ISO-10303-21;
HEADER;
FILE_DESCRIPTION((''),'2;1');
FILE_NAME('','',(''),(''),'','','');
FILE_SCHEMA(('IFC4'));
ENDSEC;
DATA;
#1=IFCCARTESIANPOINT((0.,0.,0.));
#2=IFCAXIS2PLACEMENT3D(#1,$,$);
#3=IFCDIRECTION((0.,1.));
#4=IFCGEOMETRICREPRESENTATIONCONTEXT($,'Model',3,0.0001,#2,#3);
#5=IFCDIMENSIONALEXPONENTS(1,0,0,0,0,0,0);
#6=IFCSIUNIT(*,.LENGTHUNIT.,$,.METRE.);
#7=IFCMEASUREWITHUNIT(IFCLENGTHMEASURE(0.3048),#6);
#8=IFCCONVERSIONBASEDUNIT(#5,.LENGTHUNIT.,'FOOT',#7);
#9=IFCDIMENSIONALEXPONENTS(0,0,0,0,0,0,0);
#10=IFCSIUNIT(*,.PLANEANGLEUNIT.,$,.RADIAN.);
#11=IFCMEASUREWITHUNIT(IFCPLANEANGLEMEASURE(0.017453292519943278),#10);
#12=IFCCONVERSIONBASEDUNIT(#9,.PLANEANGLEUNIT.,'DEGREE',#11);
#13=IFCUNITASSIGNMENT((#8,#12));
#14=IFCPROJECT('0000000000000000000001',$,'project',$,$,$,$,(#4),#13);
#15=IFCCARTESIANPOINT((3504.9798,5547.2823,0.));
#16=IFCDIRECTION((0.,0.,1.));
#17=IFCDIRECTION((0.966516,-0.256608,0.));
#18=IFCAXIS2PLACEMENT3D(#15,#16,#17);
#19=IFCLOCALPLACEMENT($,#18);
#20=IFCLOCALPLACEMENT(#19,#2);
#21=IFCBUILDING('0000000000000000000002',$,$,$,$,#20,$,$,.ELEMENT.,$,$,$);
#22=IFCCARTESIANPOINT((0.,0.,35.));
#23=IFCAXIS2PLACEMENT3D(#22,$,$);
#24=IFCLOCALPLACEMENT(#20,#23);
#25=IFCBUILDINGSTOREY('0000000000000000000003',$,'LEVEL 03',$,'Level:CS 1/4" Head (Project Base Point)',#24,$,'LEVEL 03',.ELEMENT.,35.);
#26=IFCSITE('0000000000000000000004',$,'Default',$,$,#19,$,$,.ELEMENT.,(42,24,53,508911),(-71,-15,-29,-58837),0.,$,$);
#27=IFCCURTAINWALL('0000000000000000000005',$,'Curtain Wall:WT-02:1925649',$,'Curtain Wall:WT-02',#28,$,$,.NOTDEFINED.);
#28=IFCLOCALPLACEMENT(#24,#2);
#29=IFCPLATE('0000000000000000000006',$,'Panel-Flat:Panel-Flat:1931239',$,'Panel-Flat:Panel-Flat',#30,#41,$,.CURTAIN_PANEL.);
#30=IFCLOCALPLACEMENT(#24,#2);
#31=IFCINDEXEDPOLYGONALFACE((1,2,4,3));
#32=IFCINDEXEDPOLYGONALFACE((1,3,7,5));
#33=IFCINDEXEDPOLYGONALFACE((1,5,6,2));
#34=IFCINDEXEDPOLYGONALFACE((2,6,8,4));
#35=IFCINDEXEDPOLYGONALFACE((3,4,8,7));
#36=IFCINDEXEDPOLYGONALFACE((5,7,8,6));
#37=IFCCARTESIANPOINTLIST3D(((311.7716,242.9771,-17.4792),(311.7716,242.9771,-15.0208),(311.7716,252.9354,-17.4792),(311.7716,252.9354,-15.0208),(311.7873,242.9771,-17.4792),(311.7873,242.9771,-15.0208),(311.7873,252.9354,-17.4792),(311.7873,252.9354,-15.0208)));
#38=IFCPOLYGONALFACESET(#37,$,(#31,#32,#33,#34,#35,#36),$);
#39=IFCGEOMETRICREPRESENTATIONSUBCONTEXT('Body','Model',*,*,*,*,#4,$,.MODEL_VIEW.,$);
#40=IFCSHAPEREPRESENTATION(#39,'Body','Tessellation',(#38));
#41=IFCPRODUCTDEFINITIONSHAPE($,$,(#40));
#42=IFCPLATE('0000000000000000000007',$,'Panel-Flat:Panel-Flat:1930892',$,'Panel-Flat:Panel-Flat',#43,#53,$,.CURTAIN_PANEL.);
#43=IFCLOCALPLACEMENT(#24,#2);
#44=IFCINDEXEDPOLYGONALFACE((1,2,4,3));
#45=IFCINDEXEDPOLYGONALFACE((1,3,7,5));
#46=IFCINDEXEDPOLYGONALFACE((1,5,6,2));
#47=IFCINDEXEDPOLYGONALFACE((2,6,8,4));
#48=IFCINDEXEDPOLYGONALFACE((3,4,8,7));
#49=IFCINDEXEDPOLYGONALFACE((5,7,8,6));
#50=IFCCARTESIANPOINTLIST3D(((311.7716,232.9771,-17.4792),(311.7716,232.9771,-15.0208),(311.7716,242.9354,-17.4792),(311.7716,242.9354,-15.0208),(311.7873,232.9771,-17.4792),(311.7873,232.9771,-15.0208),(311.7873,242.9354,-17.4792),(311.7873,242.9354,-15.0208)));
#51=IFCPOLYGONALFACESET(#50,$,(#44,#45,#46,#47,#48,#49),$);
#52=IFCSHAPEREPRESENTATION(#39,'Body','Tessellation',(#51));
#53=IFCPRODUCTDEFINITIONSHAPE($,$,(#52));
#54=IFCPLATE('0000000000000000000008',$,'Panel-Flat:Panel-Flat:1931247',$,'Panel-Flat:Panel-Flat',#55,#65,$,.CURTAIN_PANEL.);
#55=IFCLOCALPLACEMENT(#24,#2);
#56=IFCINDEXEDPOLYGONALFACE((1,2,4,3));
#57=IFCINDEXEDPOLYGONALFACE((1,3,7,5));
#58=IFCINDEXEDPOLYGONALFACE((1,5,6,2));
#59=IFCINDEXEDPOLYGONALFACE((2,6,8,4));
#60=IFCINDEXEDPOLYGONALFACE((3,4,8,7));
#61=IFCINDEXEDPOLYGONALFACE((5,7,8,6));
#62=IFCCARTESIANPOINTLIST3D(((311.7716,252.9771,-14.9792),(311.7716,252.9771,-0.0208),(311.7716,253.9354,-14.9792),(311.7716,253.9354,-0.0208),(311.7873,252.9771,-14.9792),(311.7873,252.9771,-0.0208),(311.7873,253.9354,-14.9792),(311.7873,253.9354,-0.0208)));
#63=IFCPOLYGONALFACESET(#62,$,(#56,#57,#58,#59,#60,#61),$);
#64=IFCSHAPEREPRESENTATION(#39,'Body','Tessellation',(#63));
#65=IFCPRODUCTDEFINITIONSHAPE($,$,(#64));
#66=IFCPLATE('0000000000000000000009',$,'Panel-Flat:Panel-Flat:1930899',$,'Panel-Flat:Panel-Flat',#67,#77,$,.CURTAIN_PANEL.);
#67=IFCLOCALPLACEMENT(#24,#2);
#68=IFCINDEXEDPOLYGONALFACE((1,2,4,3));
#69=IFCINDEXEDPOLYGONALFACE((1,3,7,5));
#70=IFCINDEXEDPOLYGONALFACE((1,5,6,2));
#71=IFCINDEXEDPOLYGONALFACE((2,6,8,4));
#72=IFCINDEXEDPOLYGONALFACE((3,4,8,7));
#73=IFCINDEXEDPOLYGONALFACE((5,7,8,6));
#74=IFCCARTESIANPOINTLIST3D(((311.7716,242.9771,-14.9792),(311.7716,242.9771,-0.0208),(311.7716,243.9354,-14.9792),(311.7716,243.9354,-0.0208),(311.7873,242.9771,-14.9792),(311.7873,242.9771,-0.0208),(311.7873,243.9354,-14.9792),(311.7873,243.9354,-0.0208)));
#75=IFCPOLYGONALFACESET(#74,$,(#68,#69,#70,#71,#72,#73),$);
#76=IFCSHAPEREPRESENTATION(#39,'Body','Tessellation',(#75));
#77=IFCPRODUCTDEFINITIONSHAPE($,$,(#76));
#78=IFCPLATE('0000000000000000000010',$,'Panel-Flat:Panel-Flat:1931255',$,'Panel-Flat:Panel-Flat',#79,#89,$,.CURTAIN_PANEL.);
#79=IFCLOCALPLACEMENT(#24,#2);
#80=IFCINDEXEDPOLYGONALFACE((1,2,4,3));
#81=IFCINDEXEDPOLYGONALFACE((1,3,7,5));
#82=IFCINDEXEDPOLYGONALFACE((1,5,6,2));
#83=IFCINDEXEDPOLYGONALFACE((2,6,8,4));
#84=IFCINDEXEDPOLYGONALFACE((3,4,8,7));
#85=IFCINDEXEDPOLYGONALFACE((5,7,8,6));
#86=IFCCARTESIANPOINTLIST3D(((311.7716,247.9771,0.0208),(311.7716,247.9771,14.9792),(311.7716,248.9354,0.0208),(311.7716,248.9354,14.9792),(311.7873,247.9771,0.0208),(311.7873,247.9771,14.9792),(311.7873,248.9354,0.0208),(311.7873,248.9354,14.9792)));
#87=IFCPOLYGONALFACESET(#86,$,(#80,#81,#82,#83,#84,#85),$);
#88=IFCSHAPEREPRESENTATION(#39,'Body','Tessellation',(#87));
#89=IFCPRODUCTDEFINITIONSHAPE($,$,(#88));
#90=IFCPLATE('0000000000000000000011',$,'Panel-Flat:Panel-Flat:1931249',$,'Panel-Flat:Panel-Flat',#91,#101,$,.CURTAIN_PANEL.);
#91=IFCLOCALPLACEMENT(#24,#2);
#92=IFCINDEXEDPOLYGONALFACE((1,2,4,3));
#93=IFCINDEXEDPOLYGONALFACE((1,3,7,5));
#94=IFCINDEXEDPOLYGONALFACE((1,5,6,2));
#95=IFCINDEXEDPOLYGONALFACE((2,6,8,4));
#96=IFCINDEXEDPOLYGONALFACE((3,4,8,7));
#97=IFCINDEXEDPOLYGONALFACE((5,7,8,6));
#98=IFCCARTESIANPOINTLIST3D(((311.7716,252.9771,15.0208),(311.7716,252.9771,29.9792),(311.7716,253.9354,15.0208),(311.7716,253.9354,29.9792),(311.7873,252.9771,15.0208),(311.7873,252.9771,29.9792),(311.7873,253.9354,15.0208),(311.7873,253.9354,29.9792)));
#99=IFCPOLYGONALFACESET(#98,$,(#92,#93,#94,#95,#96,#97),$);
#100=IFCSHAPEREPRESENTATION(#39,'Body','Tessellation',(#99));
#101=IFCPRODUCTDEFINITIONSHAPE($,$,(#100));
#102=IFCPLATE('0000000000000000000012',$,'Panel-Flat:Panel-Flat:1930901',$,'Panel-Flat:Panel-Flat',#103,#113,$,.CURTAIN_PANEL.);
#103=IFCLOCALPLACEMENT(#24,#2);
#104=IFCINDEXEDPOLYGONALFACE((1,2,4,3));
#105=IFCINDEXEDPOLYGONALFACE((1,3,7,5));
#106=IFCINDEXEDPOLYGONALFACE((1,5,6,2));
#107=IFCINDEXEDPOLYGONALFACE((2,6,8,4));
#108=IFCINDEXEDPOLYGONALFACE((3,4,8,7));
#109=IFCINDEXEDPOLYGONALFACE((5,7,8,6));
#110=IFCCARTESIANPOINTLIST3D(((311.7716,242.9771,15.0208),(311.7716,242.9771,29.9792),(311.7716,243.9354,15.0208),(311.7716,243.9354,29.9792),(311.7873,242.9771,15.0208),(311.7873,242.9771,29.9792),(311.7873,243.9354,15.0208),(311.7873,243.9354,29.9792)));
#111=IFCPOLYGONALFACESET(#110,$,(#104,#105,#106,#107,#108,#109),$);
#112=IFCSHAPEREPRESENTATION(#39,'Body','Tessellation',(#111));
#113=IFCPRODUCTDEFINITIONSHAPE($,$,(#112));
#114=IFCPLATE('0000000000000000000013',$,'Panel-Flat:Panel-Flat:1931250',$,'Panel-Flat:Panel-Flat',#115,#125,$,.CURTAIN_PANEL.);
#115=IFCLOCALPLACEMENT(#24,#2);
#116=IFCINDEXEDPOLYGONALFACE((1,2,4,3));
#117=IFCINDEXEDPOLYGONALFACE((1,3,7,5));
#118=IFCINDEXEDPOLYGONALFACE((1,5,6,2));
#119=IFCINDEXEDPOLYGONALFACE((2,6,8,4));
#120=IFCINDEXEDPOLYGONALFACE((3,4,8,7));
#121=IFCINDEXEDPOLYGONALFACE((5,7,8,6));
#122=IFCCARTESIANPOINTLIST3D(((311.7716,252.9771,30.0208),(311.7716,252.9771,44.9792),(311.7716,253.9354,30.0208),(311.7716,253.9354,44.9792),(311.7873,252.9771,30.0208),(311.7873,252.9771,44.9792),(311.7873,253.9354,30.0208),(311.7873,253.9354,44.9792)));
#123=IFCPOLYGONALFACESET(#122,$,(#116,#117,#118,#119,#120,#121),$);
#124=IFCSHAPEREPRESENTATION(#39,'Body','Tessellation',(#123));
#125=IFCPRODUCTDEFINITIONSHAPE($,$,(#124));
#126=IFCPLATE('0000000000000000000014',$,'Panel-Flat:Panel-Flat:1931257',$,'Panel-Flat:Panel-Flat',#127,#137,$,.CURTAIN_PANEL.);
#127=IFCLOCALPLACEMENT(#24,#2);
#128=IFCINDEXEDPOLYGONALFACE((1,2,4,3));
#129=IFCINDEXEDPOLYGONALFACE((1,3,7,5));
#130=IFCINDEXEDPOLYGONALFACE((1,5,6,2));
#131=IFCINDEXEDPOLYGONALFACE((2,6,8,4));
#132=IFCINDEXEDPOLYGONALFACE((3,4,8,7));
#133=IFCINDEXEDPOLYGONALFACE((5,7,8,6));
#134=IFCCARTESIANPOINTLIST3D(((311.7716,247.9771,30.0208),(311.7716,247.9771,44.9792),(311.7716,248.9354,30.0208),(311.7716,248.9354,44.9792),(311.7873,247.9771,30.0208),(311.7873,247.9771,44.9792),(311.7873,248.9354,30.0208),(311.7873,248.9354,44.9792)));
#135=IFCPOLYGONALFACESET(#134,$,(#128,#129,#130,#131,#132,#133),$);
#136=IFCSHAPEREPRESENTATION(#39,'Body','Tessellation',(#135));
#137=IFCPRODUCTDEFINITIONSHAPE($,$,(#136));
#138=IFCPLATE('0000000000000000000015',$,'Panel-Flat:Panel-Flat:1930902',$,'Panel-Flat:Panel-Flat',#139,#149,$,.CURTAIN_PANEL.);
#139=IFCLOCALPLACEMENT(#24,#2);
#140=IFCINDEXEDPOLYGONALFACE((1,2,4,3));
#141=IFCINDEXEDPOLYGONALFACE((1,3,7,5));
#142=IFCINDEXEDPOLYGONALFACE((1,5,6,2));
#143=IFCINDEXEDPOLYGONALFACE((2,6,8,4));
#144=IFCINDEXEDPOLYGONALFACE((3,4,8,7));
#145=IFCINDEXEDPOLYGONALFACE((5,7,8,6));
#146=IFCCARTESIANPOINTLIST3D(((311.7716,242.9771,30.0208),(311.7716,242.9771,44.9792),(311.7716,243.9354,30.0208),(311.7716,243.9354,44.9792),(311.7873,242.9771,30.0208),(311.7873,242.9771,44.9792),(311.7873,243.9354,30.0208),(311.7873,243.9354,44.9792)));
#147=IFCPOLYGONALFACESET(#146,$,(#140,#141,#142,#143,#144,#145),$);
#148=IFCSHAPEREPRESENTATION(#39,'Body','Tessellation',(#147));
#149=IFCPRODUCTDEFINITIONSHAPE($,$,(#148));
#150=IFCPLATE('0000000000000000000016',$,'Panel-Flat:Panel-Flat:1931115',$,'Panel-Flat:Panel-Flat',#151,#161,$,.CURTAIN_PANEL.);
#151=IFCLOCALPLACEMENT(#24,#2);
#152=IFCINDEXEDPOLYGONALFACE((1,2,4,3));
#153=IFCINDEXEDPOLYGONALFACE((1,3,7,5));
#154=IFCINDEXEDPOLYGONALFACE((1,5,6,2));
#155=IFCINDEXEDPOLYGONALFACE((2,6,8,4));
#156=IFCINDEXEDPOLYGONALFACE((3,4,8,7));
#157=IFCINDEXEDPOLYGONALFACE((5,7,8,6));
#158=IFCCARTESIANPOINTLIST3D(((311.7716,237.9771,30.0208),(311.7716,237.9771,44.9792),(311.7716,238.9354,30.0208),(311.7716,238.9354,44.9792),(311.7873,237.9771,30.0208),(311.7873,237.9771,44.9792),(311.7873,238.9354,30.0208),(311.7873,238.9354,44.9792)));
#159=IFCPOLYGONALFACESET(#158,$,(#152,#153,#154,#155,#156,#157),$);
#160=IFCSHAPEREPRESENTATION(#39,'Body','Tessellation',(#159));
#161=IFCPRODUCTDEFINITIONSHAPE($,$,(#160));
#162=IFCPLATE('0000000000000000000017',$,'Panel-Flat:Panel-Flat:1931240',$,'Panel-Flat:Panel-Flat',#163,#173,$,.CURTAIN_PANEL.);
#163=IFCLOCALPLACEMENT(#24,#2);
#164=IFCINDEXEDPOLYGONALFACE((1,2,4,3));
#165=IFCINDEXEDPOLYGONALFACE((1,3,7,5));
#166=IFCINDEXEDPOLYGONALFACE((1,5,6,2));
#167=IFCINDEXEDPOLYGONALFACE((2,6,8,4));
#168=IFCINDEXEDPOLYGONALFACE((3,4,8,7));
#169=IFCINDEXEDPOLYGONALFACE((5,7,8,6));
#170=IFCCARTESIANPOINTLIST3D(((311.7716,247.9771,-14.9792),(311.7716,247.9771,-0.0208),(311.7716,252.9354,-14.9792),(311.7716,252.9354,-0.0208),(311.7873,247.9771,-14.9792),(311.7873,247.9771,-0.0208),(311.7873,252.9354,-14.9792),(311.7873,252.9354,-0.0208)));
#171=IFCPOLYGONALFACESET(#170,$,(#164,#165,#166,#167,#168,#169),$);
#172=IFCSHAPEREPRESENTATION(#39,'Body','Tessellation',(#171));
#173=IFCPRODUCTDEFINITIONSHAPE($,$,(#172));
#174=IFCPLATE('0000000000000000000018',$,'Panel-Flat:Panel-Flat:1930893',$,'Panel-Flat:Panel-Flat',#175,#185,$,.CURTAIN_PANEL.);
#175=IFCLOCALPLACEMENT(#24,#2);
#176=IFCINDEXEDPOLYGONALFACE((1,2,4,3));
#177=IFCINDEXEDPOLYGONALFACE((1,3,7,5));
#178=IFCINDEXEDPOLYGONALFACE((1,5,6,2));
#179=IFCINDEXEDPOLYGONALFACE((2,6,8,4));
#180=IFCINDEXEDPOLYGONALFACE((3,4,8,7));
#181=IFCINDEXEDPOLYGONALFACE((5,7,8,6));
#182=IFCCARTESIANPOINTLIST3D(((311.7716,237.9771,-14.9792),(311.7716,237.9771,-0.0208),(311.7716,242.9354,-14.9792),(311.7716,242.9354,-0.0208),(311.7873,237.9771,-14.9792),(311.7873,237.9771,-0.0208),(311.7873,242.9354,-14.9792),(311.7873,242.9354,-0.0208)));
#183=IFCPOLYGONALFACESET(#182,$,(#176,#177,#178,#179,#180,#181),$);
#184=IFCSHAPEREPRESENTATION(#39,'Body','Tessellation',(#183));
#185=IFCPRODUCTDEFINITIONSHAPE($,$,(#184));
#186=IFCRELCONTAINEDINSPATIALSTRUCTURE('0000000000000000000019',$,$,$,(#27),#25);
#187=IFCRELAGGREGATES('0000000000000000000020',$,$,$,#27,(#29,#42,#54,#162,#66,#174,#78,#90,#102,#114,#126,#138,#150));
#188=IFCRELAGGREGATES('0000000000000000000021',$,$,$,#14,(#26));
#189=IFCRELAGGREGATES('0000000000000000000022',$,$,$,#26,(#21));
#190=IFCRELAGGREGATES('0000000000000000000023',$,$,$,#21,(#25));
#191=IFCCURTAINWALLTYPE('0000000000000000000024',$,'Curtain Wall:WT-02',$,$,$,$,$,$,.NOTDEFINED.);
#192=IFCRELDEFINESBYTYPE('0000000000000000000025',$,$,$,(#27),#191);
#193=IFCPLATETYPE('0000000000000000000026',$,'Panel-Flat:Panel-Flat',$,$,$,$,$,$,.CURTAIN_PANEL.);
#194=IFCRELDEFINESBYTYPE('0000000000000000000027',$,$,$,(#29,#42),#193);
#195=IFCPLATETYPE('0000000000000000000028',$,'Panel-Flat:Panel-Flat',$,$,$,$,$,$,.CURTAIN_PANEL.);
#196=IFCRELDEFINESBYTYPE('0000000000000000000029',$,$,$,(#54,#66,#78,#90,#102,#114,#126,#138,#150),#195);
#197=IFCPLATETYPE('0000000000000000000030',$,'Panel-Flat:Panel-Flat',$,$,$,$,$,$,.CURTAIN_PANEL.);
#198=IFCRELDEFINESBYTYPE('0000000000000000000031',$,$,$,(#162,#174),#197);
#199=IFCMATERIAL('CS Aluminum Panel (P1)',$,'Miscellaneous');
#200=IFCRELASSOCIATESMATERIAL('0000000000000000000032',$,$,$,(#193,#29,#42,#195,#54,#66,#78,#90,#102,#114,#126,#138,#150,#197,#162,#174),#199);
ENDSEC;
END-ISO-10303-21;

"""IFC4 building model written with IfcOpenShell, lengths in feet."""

from ifc_helpers import new_model, entity, si_unit, converted_unit, direction, frame, origin, place, context, subcontext, project, spatial, indexed_curve, outline, extrude, source, transform, mapped, material, type_object, type_shapes, element, aggregate, save


model = new_model("IFC4")

# Units and contexts
model_context = context("Model", 3, precision=0.0001, world=origin(), true_north=direction((0.0, 1.0)))
body_context = subcontext(model_context, "Body", "Model", "MODEL_VIEW")
ifc_project = project(units=[converted_unit("LENGTHUNIT", "FOOT", entity("IfcLengthMeasure", 0.3048), si_unit("LENGTHUNIT", "METRE"), dimensions=[1, 0, 0, 0, 0, 0, 0]), converted_unit("PLANEANGLEUNIT", "DEGREE", entity("IfcPlaneAngleMeasure", 0.017453292519943278), si_unit("PLANEANGLEUNIT", "RADIAN"), dimensions=[0, 0, 0, 0, 0, 0, 0])], contexts=[model_context])

# Site, building, storey
site_placement = place(None, frame((3504.9798, 5547.2823, 0.0), z_axis=(0.0, 0.0, 1.0), x_axis=(0.966516, -0.256608, 0.0)))
site = spatial("IfcSite", under=ifc_project, at=site_placement, Name="Default", CompositionType="ELEMENT", RefLatitude=(42, 24, 53, 508911), RefLongitude=(-71, -15, -29, -58837), RefElevation=0.0)
building_placement = place(site_placement, origin())
building = spatial("IfcBuilding", under=site, at=building_placement, CompositionType="ELEMENT")
storey_placement = place(building_placement, frame((0.0, 0.0, 35.0)))
storey = spatial("IfcBuildingStorey", under=building, at=storey_placement, Name="LEVEL 03", ObjectType="Level:CS 1/4\" Head (Project Base Point)", LongName="LEVEL 03", CompositionType="ELEMENT", Elevation=35.0)

# Curtain wall, plates
curtain_wall_type = type_object("IfcCurtainWallType", Name="Curtain Wall:WT-02", PredefinedType="NOTDEFINED")
curtain_wall_1_placement = place(storey_placement, frame((0.0, 0.0, -35.0)))
curtain_wall_1 = element("IfcCurtainWall", 1, at=curtain_wall_1_placement, inside=storey, type_object=curtain_wall_type, Name="Curtain Wall:WT-02:1925649", ObjectType="Curtain Wall:WT-02", PredefinedType="NOTDEFINED")
ifc_material_1 = material(Name="CS Aluminum Panel (P1)", Category="Miscellaneous")
plate_type_1 = type_object("IfcPlateType", Name="Panel-Flat:Panel-Flat", PredefinedType="CURTAIN_PANEL", material=ifc_material_1)
shared_shape_1 = source(origin(), body_context, "Body", "SweptSolid", [
    extrude(outline(indexed_curve([(-0.0078, -4.9792), (0.0078, -4.9792), (0.0078, 4.9792), (-0.0078, 4.9792), (-0.0078, -4.9792)], self_intersect=False)), frame((4.9792, 0.0078, 0.0), z_axis=(0.0, 0.0, 1.0), x_axis=(0.0, -1.0, 0.0)), (0.0, 0.0, 1.0), 2.4583),
])
type_shapes(plate_type_1, [shared_shape_1])
plate_1_placement = place(curtain_wall_1_placement, frame((311.7716, 252.9354, 17.5208), z_axis=(0.0, 0.0, 1.0), x_axis=(0.0, -1.0, 0.0)))
plate_1 = element("IfcPlate", 2, at=plate_1_placement, type_object=plate_type_1, material=ifc_material_1, Name="Panel-Flat:Panel-Flat:1931239", ObjectType="Panel-Flat:Panel-Flat", PredefinedType="CURTAIN_PANEL", context=body_context, shape_type="MappedRepresentation", body=[
    mapped(shared_shape_1, transform((0.0, 0.0, 0.0), scale=1.0)),
])
plate_2_placement = place(curtain_wall_1_placement, frame((311.7716, 242.9354, 17.5208), z_axis=(0.0, 0.0, 1.0), x_axis=(0.0, -1.0, 0.0)))
plate_2 = element("IfcPlate", 3, at=plate_2_placement, type_object=plate_type_1, material=ifc_material_1, Name="Panel-Flat:Panel-Flat:1930892", ObjectType="Panel-Flat:Panel-Flat", PredefinedType="CURTAIN_PANEL", context=body_context, shape_type="MappedRepresentation", body=[
    mapped(shared_shape_1, transform((0.0, 0.0, 0.0), scale=1.0)),
])
plate_type_2 = type_object("IfcPlateType", Name="Panel-Flat:Panel-Flat", PredefinedType="CURTAIN_PANEL", material=ifc_material_1)
shared_shape_2 = source(origin(), body_context, "Body", "SweptSolid", [
    extrude(outline(indexed_curve([(-0.0078, -0.4792), (0.0078, -0.4792), (0.0078, 0.4792), (-0.0078, 0.4792), (-0.0078, -0.4792)], self_intersect=False)), frame((0.4792, 0.0078, 0.0), z_axis=(0.0, 0.0, 1.0), x_axis=(0.0, -1.0, 0.0)), (0.0, 0.0, 1.0), 14.9583),
])
type_shapes(plate_type_2, [shared_shape_2])
plate_3_placement = place(curtain_wall_1_placement, frame((311.7716, 253.9354, 20.0208), z_axis=(0.0, 0.0, 1.0), x_axis=(0.0, -1.0, 0.0)))
plate_3 = element("IfcPlate", 4, at=plate_3_placement, type_object=plate_type_2, material=ifc_material_1, Name="Panel-Flat:Panel-Flat:1931247", ObjectType="Panel-Flat:Panel-Flat", PredefinedType="CURTAIN_PANEL", context=body_context, shape_type="MappedRepresentation", body=[
    mapped(shared_shape_2, transform((0.0, 0.0, 0.0), scale=1.0)),
])
plate_4_placement = place(curtain_wall_1_placement, frame((311.7716, 243.9354, 20.0208), z_axis=(0.0, 0.0, 1.0), x_axis=(0.0, -1.0, 0.0)))
plate_4 = element("IfcPlate", 5, at=plate_4_placement, type_object=plate_type_2, material=ifc_material_1, Name="Panel-Flat:Panel-Flat:1930899", ObjectType="Panel-Flat:Panel-Flat", PredefinedType="CURTAIN_PANEL", context=body_context, shape_type="MappedRepresentation", body=[
    mapped(shared_shape_2, transform((0.0, 0.0, 0.0), scale=1.0)),
])
plate_5_placement = place(curtain_wall_1_placement, frame((311.7716, 248.9354, 35.0208), z_axis=(0.0, 0.0, 1.0), x_axis=(0.0, -1.0, 0.0)))
plate_5 = element("IfcPlate", 6, at=plate_5_placement, type_object=plate_type_2, material=ifc_material_1, Name="Panel-Flat:Panel-Flat:1931255", ObjectType="Panel-Flat:Panel-Flat", PredefinedType="CURTAIN_PANEL", context=body_context, shape_type="MappedRepresentation", body=[
    mapped(shared_shape_2, transform((0.0, 0.0, 0.0), scale=1.0)),
])
plate_6_placement = place(curtain_wall_1_placement, frame((311.7716, 253.9354, 50.0208), z_axis=(0.0, 0.0, 1.0), x_axis=(0.0, -1.0, 0.0)))
plate_6 = element("IfcPlate", 7, at=plate_6_placement, type_object=plate_type_2, material=ifc_material_1, Name="Panel-Flat:Panel-Flat:1931249", ObjectType="Panel-Flat:Panel-Flat", PredefinedType="CURTAIN_PANEL", context=body_context, shape_type="MappedRepresentation", body=[
    mapped(shared_shape_2, transform((0.0, 0.0, 0.0), scale=1.0)),
])
plate_7_placement = place(curtain_wall_1_placement, frame((311.7716, 243.9354, 50.0208), z_axis=(0.0, 0.0, 1.0), x_axis=(0.0, -1.0, 0.0)))
plate_7 = element("IfcPlate", 8, at=plate_7_placement, type_object=plate_type_2, material=ifc_material_1, Name="Panel-Flat:Panel-Flat:1930901", ObjectType="Panel-Flat:Panel-Flat", PredefinedType="CURTAIN_PANEL", context=body_context, shape_type="MappedRepresentation", body=[
    mapped(shared_shape_2, transform((0.0, 0.0, 0.0), scale=1.0)),
])
plate_8_placement = place(curtain_wall_1_placement, frame((311.7716, 253.9354, 65.0208), z_axis=(0.0, 0.0, 1.0), x_axis=(0.0, -1.0, 0.0)))
plate_8 = element("IfcPlate", 9, at=plate_8_placement, type_object=plate_type_2, material=ifc_material_1, Name="Panel-Flat:Panel-Flat:1931250", ObjectType="Panel-Flat:Panel-Flat", PredefinedType="CURTAIN_PANEL", context=body_context, shape_type="MappedRepresentation", body=[
    mapped(shared_shape_2, transform((0.0, 0.0, 0.0), scale=1.0)),
])
plate_9_placement = place(curtain_wall_1_placement, frame((311.7716, 248.9354, 65.0208), z_axis=(0.0, 0.0, 1.0), x_axis=(0.0, -1.0, 0.0)))
plate_9 = element("IfcPlate", 10, at=plate_9_placement, type_object=plate_type_2, material=ifc_material_1, Name="Panel-Flat:Panel-Flat:1931257", ObjectType="Panel-Flat:Panel-Flat", PredefinedType="CURTAIN_PANEL", context=body_context, shape_type="MappedRepresentation", body=[
    mapped(shared_shape_2, transform((0.0, 0.0, 0.0), scale=1.0)),
])
plate_10_placement = place(curtain_wall_1_placement, frame((311.7716, 243.9354, 65.0208), z_axis=(0.0, 0.0, 1.0), x_axis=(0.0, -1.0, 0.0)))
plate_10 = element("IfcPlate", 11, at=plate_10_placement, type_object=plate_type_2, material=ifc_material_1, Name="Panel-Flat:Panel-Flat:1930902", ObjectType="Panel-Flat:Panel-Flat", PredefinedType="CURTAIN_PANEL", context=body_context, shape_type="MappedRepresentation", body=[
    mapped(shared_shape_2, transform((0.0, 0.0, 0.0), scale=1.0)),
])
plate_11_placement = place(curtain_wall_1_placement, frame((311.7716, 238.9354, 65.0208), z_axis=(0.0, 0.0, 1.0), x_axis=(0.0, -1.0, 0.0)))
plate_11 = element("IfcPlate", 12, at=plate_11_placement, type_object=plate_type_2, material=ifc_material_1, Name="Panel-Flat:Panel-Flat:1931115", ObjectType="Panel-Flat:Panel-Flat", PredefinedType="CURTAIN_PANEL", context=body_context, shape_type="MappedRepresentation", body=[
    mapped(shared_shape_2, transform((0.0, 0.0, 0.0), scale=1.0)),
])
plate_type_3 = type_object("IfcPlateType", Name="Panel-Flat:Panel-Flat", PredefinedType="CURTAIN_PANEL", material=ifc_material_1)
shared_shape_3 = source(origin(), body_context, "Body", "SweptSolid", [
    extrude(outline(indexed_curve([(-0.0078, -2.4792), (0.0078, -2.4792), (0.0078, 2.4792), (-0.0078, 2.4792), (-0.0078, -2.4792)], self_intersect=False)), frame((2.4792, 0.0078, 0.0), z_axis=(0.0, 0.0, 1.0), x_axis=(0.0, -1.0, 0.0)), (0.0, 0.0, 1.0), 14.9583),
])
type_shapes(plate_type_3, [shared_shape_3])
plate_12_placement = place(curtain_wall_1_placement, frame((311.7716, 252.9354, 20.0208), z_axis=(0.0, 0.0, 1.0), x_axis=(0.0, -1.0, 0.0)))
plate_12 = element("IfcPlate", 13, at=plate_12_placement, type_object=plate_type_3, material=ifc_material_1, Name="Panel-Flat:Panel-Flat:1931240", ObjectType="Panel-Flat:Panel-Flat", PredefinedType="CURTAIN_PANEL", context=body_context, shape_type="MappedRepresentation", body=[
    mapped(shared_shape_3, transform((0.0, 0.0, 0.0), scale=1.0)),
])
plate_13_placement = place(curtain_wall_1_placement, frame((311.7716, 242.9354, 20.0208), z_axis=(0.0, 0.0, 1.0), x_axis=(0.0, -1.0, 0.0)))
plate_13 = element("IfcPlate", 14, at=plate_13_placement, type_object=plate_type_3, material=ifc_material_1, Name="Panel-Flat:Panel-Flat:1930893", ObjectType="Panel-Flat:Panel-Flat", PredefinedType="CURTAIN_PANEL", context=body_context, shape_type="MappedRepresentation", body=[
    mapped(shared_shape_3, transform((0.0, 0.0, 0.0), scale=1.0)),
])
aggregate(curtain_wall_1, [plate_1, plate_2, plate_3, plate_12, plate_4, plate_13, plate_5, plate_6, plate_7, plate_8, plate_9, plate_10, plate_11])

save(model, "model.ifc")
